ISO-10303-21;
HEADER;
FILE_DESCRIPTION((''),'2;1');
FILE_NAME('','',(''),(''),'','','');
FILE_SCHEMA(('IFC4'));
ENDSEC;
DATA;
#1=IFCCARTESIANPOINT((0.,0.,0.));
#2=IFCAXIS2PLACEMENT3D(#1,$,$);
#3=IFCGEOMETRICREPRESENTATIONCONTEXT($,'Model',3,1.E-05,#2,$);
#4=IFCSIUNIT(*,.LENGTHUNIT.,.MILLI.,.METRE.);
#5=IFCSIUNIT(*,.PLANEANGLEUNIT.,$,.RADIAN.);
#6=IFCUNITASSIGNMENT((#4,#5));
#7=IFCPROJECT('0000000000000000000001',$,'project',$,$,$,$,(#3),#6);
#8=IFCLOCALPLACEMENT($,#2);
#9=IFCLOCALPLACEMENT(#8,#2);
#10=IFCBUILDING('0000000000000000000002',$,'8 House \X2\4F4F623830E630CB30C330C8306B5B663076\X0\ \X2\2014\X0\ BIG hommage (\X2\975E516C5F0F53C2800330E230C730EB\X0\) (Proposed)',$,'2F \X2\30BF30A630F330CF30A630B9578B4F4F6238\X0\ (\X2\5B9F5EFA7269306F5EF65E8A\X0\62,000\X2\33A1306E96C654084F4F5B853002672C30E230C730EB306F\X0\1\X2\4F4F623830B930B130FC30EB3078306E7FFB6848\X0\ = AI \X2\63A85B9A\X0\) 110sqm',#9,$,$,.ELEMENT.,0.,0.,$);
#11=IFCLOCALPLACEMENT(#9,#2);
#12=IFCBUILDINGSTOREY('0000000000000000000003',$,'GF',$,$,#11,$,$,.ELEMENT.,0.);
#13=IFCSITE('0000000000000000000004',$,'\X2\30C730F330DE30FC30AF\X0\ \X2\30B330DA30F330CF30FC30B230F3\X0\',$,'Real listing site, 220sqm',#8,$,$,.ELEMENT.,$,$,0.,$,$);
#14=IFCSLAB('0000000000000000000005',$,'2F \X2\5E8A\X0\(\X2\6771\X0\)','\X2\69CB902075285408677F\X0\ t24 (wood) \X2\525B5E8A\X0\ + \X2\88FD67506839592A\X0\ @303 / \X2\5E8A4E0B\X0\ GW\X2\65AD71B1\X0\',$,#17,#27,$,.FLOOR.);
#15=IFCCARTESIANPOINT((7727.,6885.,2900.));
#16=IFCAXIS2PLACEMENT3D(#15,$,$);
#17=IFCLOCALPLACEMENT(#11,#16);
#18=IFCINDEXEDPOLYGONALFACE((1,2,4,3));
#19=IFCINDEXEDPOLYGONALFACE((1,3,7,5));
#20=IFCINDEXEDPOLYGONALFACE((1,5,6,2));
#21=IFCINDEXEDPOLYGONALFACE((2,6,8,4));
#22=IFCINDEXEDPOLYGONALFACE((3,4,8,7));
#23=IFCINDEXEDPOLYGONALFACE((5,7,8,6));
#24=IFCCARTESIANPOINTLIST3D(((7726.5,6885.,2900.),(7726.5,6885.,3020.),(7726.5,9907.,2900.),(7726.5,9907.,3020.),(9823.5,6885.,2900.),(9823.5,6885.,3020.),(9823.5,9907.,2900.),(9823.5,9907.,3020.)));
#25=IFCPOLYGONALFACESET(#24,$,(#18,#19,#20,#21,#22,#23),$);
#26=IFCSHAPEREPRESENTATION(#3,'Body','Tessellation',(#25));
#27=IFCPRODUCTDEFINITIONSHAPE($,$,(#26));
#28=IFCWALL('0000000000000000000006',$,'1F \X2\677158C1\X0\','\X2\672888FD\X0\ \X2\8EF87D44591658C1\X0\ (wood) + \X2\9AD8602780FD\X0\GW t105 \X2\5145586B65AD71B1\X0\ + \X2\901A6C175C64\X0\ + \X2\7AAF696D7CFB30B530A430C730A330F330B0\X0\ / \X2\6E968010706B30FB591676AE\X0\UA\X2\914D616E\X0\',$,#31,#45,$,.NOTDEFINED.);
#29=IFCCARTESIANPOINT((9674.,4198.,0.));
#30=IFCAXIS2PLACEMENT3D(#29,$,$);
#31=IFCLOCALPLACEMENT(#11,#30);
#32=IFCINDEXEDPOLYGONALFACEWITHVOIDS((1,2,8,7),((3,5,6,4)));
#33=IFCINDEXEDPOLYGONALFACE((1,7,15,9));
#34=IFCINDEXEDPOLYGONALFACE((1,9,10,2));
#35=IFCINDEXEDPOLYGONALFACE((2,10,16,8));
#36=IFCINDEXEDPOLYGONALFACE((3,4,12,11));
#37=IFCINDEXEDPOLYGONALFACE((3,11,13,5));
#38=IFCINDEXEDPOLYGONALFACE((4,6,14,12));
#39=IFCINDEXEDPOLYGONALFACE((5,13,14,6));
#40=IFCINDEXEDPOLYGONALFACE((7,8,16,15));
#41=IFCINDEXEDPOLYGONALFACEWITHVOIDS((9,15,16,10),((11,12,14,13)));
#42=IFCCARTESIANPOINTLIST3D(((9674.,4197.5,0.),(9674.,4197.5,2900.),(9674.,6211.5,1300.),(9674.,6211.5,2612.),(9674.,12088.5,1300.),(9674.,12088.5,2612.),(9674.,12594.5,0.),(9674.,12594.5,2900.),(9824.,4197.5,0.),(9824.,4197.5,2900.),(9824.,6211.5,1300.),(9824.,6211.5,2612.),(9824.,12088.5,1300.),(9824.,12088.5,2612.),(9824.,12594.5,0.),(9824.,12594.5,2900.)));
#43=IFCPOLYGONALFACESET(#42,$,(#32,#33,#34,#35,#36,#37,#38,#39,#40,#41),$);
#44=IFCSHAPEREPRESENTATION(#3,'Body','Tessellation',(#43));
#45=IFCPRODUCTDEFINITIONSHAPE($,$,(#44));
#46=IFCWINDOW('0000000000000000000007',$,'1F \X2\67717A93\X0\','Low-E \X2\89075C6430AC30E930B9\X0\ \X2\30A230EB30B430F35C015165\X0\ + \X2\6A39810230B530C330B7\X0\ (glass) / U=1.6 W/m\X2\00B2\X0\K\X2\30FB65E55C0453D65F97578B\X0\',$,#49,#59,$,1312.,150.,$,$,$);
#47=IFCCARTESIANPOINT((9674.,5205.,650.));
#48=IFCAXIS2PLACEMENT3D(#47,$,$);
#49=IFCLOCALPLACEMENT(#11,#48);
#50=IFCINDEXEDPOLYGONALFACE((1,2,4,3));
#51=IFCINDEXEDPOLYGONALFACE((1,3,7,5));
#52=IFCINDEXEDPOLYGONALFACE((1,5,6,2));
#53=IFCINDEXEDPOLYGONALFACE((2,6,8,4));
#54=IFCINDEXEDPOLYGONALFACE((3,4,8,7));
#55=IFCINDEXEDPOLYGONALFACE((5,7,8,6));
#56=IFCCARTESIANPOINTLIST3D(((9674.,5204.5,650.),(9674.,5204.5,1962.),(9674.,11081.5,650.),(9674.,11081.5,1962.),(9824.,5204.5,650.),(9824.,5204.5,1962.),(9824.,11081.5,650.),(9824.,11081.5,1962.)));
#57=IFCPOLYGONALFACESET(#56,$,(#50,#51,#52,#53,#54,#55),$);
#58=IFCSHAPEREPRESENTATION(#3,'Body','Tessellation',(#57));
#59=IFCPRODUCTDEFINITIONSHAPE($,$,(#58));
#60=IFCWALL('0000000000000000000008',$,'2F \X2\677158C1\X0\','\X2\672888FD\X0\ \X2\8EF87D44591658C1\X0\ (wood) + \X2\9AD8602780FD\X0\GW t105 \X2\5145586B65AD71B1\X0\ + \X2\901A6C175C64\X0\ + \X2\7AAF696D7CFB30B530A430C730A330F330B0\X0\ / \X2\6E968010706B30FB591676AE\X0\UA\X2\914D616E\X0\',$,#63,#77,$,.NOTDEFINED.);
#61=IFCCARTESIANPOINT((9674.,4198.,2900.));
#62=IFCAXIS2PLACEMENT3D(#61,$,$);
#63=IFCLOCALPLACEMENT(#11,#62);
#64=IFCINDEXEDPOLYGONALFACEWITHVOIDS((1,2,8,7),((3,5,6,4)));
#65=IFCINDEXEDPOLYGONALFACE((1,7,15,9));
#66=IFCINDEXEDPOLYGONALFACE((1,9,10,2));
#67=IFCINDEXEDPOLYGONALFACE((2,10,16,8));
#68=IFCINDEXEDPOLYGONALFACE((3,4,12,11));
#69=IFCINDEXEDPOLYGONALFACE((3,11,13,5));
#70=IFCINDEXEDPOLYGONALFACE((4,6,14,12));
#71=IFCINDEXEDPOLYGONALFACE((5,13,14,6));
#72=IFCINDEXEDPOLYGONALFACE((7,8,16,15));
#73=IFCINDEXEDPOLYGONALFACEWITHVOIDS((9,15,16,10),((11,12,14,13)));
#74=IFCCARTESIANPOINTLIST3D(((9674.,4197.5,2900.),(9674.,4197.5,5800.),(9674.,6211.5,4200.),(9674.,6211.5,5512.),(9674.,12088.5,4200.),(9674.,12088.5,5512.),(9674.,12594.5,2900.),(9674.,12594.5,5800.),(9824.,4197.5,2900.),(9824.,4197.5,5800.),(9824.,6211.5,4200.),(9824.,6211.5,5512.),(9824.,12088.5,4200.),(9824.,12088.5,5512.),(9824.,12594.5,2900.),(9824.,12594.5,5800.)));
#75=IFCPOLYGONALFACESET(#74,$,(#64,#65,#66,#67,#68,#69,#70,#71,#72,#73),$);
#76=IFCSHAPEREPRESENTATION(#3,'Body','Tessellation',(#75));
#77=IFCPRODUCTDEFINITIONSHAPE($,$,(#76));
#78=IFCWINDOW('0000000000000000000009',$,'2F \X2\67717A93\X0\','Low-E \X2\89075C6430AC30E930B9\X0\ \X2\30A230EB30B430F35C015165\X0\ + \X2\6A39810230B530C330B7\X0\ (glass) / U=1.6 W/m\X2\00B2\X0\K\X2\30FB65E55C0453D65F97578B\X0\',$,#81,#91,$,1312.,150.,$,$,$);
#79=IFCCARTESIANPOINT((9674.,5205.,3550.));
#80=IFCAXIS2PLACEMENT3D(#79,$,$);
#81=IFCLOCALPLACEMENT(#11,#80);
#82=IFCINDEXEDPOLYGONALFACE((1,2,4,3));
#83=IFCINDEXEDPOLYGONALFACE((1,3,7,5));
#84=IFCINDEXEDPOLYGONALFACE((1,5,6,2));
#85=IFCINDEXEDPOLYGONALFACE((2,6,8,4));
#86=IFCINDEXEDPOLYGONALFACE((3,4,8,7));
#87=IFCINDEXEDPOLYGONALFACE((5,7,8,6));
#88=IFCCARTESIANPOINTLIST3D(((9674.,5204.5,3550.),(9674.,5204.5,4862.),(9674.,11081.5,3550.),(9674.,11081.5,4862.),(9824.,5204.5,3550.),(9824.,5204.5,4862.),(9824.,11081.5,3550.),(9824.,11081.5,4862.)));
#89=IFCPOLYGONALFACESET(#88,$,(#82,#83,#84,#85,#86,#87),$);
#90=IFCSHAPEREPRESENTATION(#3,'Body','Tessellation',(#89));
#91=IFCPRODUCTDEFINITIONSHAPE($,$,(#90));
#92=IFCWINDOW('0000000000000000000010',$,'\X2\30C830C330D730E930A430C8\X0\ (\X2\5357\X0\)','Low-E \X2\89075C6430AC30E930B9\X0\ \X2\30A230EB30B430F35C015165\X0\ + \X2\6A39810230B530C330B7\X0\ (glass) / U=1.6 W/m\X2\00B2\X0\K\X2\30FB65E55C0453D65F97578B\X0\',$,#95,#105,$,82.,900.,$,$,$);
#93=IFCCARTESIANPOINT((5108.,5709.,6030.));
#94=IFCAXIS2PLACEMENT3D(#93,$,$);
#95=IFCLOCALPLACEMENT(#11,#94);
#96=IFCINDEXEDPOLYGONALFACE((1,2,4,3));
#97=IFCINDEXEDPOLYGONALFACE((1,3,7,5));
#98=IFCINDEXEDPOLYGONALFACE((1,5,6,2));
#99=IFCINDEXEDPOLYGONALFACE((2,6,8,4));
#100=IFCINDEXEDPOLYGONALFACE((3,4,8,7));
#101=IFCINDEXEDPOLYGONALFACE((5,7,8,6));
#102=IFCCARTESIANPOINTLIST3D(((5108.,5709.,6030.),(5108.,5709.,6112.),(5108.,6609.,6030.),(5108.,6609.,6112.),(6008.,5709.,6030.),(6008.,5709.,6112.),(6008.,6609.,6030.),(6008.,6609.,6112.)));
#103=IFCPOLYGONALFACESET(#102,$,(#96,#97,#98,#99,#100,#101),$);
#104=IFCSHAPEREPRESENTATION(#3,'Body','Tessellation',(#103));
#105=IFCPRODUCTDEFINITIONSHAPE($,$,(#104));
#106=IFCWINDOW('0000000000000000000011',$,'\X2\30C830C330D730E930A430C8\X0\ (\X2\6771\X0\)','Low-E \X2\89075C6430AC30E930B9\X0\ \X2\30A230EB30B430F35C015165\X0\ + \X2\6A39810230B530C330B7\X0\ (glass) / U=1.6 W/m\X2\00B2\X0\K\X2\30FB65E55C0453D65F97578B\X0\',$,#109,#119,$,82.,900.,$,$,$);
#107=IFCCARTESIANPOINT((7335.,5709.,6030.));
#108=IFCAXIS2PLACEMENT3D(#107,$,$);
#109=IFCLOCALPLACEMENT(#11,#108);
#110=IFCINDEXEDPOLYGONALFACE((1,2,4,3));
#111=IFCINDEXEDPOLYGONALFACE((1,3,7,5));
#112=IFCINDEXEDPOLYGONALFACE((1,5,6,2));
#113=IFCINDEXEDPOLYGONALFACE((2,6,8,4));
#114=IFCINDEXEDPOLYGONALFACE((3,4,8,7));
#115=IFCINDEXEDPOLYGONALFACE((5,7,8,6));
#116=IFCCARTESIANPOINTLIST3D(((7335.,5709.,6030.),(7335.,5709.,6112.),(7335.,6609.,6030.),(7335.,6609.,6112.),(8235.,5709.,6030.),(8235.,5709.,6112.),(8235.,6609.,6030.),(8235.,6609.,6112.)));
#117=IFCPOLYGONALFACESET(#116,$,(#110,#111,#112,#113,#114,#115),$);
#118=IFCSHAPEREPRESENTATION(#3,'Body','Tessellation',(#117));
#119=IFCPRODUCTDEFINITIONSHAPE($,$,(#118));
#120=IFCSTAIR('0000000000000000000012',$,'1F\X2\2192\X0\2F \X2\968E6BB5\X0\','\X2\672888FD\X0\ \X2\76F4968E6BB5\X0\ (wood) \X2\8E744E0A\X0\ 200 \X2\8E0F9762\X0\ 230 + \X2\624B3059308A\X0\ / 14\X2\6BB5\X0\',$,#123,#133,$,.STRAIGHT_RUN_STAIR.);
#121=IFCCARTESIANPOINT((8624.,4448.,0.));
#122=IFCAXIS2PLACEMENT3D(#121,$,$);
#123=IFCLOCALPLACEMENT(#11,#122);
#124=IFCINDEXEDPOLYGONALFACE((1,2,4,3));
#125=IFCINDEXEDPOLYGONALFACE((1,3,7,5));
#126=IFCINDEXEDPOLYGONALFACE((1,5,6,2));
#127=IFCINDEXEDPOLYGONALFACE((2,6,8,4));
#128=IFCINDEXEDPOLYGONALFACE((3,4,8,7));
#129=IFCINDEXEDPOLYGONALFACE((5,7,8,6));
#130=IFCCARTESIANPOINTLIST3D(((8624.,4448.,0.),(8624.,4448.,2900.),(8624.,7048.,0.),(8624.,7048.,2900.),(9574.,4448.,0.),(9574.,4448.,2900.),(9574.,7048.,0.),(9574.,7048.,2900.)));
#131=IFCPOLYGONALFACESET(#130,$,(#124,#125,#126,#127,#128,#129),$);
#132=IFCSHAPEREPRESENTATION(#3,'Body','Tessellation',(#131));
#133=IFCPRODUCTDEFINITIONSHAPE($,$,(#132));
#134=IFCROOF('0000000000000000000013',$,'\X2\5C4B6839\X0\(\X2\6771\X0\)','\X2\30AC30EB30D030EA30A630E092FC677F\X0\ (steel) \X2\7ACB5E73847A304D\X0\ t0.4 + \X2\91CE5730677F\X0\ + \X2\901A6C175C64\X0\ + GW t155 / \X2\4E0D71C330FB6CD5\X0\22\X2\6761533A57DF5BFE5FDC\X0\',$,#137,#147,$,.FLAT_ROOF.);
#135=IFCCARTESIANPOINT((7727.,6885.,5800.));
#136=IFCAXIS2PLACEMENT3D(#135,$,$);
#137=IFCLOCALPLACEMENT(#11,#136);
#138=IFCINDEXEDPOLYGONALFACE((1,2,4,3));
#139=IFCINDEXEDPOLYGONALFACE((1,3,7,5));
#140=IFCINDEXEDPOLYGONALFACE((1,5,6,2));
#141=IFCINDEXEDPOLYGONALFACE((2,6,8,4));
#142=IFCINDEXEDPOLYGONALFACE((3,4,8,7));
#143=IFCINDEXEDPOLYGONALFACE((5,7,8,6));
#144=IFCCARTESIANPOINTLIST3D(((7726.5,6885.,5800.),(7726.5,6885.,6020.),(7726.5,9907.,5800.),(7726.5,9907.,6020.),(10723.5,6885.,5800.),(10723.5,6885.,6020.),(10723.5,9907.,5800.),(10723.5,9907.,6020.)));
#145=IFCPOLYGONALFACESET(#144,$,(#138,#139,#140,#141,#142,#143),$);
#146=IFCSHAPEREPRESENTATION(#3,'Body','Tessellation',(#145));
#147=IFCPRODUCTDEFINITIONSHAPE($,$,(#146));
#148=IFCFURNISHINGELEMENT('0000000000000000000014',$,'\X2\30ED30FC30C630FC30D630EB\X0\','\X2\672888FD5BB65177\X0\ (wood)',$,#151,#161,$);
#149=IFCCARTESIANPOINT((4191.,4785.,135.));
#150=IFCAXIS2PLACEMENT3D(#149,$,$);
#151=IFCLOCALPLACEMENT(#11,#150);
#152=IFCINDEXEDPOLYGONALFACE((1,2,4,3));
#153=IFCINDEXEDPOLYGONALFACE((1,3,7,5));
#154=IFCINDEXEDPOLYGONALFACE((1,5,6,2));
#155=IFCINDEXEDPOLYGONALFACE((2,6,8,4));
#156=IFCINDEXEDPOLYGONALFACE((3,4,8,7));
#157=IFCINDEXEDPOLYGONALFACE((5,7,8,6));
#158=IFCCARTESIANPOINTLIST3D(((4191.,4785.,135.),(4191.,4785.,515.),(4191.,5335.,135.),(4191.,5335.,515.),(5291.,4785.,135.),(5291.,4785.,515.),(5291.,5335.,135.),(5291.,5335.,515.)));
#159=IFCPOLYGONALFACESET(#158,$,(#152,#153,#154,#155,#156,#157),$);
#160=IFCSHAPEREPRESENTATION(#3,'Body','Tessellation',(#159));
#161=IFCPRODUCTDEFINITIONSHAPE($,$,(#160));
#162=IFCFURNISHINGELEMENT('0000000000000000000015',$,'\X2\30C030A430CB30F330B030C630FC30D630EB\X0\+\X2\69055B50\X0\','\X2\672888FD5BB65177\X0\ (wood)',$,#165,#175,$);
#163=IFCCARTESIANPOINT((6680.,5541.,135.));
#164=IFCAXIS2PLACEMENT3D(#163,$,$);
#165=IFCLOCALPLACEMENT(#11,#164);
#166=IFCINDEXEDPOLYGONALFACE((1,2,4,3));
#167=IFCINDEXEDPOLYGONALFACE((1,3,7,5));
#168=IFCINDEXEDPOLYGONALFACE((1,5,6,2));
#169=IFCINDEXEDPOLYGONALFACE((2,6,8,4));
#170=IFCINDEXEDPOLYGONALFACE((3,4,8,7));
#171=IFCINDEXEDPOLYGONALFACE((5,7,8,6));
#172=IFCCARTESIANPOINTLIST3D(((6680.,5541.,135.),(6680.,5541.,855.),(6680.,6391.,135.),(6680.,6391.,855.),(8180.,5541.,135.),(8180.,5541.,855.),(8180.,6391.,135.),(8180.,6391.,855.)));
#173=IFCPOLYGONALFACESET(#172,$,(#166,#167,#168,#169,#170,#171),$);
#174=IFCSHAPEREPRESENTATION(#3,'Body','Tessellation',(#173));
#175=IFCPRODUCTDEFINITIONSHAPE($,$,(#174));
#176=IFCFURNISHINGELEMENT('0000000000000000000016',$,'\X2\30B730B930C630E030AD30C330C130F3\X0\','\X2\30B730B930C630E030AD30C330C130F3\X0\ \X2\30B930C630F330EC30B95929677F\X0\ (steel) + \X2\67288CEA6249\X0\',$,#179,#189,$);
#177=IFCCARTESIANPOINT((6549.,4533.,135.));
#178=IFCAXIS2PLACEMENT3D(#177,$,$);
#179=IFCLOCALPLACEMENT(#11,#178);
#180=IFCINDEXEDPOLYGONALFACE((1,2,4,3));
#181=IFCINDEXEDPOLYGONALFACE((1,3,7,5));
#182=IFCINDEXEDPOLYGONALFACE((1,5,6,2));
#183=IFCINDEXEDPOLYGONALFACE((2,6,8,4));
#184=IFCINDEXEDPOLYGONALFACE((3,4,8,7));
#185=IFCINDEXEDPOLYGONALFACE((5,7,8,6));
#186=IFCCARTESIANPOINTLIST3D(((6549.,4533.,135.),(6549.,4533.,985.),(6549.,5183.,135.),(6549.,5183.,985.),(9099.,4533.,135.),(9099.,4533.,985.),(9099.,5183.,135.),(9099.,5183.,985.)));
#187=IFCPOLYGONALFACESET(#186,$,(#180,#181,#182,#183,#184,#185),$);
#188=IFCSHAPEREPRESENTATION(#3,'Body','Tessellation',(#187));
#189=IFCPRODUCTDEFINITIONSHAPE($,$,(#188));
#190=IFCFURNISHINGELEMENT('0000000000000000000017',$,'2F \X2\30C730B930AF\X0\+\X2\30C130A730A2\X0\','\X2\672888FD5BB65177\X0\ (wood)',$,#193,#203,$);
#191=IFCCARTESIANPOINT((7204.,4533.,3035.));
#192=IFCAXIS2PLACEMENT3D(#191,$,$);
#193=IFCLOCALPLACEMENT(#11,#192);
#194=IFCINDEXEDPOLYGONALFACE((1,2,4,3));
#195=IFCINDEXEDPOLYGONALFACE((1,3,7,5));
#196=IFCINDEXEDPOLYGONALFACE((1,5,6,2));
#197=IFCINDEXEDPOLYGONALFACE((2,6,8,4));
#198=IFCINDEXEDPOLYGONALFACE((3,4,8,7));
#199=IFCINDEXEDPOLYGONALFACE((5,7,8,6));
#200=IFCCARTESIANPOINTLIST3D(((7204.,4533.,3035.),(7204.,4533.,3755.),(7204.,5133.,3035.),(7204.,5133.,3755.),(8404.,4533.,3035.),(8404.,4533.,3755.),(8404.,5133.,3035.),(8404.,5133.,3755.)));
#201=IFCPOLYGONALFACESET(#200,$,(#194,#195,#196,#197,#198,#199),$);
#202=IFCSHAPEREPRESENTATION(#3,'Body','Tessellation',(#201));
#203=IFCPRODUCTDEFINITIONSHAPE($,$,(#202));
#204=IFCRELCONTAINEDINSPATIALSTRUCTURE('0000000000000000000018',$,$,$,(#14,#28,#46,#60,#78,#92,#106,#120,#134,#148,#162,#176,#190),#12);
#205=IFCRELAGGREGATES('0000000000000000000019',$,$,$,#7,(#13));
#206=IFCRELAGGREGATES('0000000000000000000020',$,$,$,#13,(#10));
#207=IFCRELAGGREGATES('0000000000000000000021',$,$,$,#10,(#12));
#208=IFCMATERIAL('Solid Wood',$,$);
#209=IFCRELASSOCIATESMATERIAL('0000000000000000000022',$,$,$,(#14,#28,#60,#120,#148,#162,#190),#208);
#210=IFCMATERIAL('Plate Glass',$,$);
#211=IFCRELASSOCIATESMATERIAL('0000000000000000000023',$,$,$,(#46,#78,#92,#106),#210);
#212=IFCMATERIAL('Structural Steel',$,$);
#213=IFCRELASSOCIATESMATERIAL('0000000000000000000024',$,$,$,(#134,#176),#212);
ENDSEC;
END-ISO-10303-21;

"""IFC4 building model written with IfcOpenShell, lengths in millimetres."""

from ifc_helpers import new_model, si_unit, frame, frame_2d, origin, place, context, project, spatial, rectangle, extrude, material, element, fill, save


model = new_model("IFC4")

# Units and contexts
model_context = context("Model", 3, precision=1e-05, world=origin())
ifc_project = project(units=[si_unit("LENGTHUNIT", "METRE", prefix="MILLI"), si_unit("PLANEANGLEUNIT", "RADIAN")], contexts=[model_context])

# Site, building, storey
site_placement = place(None, origin())
site = spatial("IfcSite", under=ifc_project, at=site_placement, Name="デンマーク コペンハーゲン", ObjectType="Real listing site, 220sqm", CompositionType="ELEMENT", RefElevation=0.0)
building_placement = place(site_placement, origin())
building = spatial("IfcBuilding", under=site, at=building_placement, Name="8 House 住戸ユニットに学ぶ — BIG hommage (非公式参考モデル) (Proposed)", ObjectType="2F タウンハウス型住戸 (実建物は延床62,000㎡の集合住宅。本モデルは1住戸スケールへの翻案 = AI 推定) 110sqm", CompositionType="ELEMENT", ElevationOfRefHeight=0.0, ElevationOfTerrain=0.0)
storey_placement = place(building_placement, origin())
storey = spatial("IfcBuildingStorey", under=building, at=storey_placement, Name="GF", CompositionType="ELEMENT", Elevation=0.0)

# Slab
ifc_material_1 = material(Name="Solid Wood")
slab_1_placement = place(storey_placement, frame((7727.0, 6885.0, 2900.0)))
element("IfcSlab", 1, at=slab_1_placement, inside=storey, material=ifc_material_1, Name="2F 床(東)", Description="構造用合板 t24 (wood) 剛床 + 製材根太 @303 / 床下 GW断熱", PredefinedType="FLOOR", context=model_context, shape_type="SweptSolid", body=[
    extrude(rectangle(XDim=2097.0, YDim=3022.0, at=frame_2d((1048.0, 1511.0))), frame((7727.0, 6885.0, 2900.0)), (0.0, 0.0, 1.0), 120.0),
])

# Wall, opening, window
wall_1_placement = place(storey_placement, frame((9674.0, 4198.0, 0.0)))
wall_1 = element("IfcWall", 2, at=wall_1_placement, inside=storey, material=ifc_material_1, Name="1F 東壁", Description="木製 軸組外壁 (wood) + 高性能GW t105 充填断熱 + 通気層 + 窯業系サイディング / 準耐火・外皮UA配慮", PredefinedType="NOTDEFINED", context=model_context, shape_type="SweptSolid", body=[
    extrude(rectangle(XDim=150.0, YDim=8397.0, at=frame_2d((75.0, 4198.0))), frame((9674.0, 4198.0, 0.0)), (0.0, 0.0, 1.0), 2900.0),
])
opening_1_placement = place(storey_placement, frame((9674.0, 5205.0, 650.0)))
opening_1 = element("IfcOpeningElement", 3, at=opening_1_placement, cuts=wall_1, PredefinedType="NOTDEFINED", context=model_context, shape_type="SweptSolid", body=[
    extrude(rectangle(XDim=150.0, YDim=5877.0, at=frame_2d((75.0, 2938.0))), frame((9674.0, 5205.0, 650.0)), (0.0, 0.0, 1.0), 1312.0),
])
ifc_material_2 = material(Name="Plate Glass")
window_1_placement = place(storey_placement, frame((9674.0, 5205.0, 650.0)))
window_1 = element("IfcWindow", 4, at=window_1_placement, inside=storey, material=ifc_material_2, Name="1F 東窓", Description="Low-E 複層ガラス アルゴン封入 + 樹脂サッシ (glass) / U=1.6 W/m²K・日射取得型", OverallHeight=1312.0, OverallWidth=150.0, context=model_context, shape_type="SweptSolid", body=[
    extrude(rectangle(XDim=150.0, YDim=5877.0, at=frame_2d((75.0, 2938.0))), frame((9674.0, 5205.0, 650.0)), (0.0, 0.0, 1.0), 1312.0),
])
fill(opening_1, window_1)

# Wall, opening, window
wall_2_placement = place(storey_placement, frame((9674.0, 4198.0, 2900.0)))
wall_2 = element("IfcWall", 5, at=wall_2_placement, inside=storey, material=ifc_material_1, Name="2F 東壁", Description="木製 軸組外壁 (wood) + 高性能GW t105 充填断熱 + 通気層 + 窯業系サイディング / 準耐火・外皮UA配慮", PredefinedType="NOTDEFINED", context=model_context, shape_type="SweptSolid", body=[
    extrude(rectangle(XDim=150.0, YDim=8397.0, at=frame_2d((75.0, 4198.0))), frame((9674.0, 4198.0, 2900.0)), (0.0, 0.0, 1.0), 2900.0),
])
opening_2_placement = place(storey_placement, frame((9674.0, 5205.0, 3550.0)))
opening_2 = element("IfcOpeningElement", 6, at=opening_2_placement, cuts=wall_2, PredefinedType="NOTDEFINED", context=model_context, shape_type="SweptSolid", body=[
    extrude(rectangle(XDim=150.0, YDim=5877.0, at=frame_2d((75.0, 2938.0))), frame((9674.0, 5205.0, 3550.0)), (0.0, 0.0, 1.0), 1312.0),
])
window_2_placement = place(storey_placement, frame((9674.0, 5205.0, 3550.0)))
window_2 = element("IfcWindow", 7, at=window_2_placement, inside=storey, material=ifc_material_2, Name="2F 東窓", Description="Low-E 複層ガラス アルゴン封入 + 樹脂サッシ (glass) / U=1.6 W/m²K・日射取得型", OverallHeight=1312.0, OverallWidth=150.0, context=model_context, shape_type="SweptSolid", body=[
    extrude(rectangle(XDim=150.0, YDim=5877.0, at=frame_2d((75.0, 2938.0))), frame((9674.0, 5205.0, 3550.0)), (0.0, 0.0, 1.0), 1312.0),
])
fill(opening_2, window_2)

# Windows
window_3_placement = place(storey_placement, frame((5108.0, 5709.0, 6030.0)))
element("IfcWindow", 8, at=window_3_placement, inside=storey, material=ifc_material_2, Name="トップライト (南)", Description="Low-E 複層ガラス アルゴン封入 + 樹脂サッシ (glass) / U=1.6 W/m²K・日射取得型", OverallHeight=82.0, OverallWidth=900.0, context=model_context, shape_type="SweptSolid", body=[
    extrude(rectangle(XDim=900.0, YDim=900.0, at=frame_2d((450.0, 450.0))), frame((5108.0, 5709.0, 6030.0)), (0.0, 0.0, 1.0), 82.0),
])
window_4_placement = place(storey_placement, frame((7335.0, 5709.0, 6030.0)))
element("IfcWindow", 9, at=window_4_placement, inside=storey, material=ifc_material_2, Name="トップライト (東)", Description="Low-E 複層ガラス アルゴン封入 + 樹脂サッシ (glass) / U=1.6 W/m²K・日射取得型", OverallHeight=82.0, OverallWidth=900.0, context=model_context, shape_type="SweptSolid", body=[
    extrude(rectangle(XDim=900.0, YDim=900.0, at=frame_2d((450.0, 450.0))), frame((7335.0, 5709.0, 6030.0)), (0.0, 0.0, 1.0), 82.0),
])

# Stair
stair_placement = place(storey_placement, frame((8624.0, 4448.0, 0.0)))
element("IfcStair", 10, at=stair_placement, inside=storey, material=ifc_material_1, Name="1F→2F 階段", Description="木製 直階段 (wood) 蹴上 200 踏面 230 + 手すり / 14段", PredefinedType="STRAIGHT_RUN_STAIR", context=model_context, shape_type="SweptSolid", body=[
    extrude(rectangle(XDim=950.0, YDim=2600.0, at=frame_2d((475.0, 1300.0))), frame((8624.0, 4448.0, 0.0)), (0.0, 0.0, 1.0), 2900.0),
])

# Roof
ifc_material_3 = material(Name="Structural Steel")
roof_placement = place(storey_placement, frame((7727.0, 6885.0, 5800.0)))
element("IfcRoof", 11, at=roof_placement, inside=storey, material=ifc_material_3, Name="屋根(東)", Description="ガルバリウム鋼板 (steel) 立平葺き t0.4 + 野地板 + 通気層 + GW t155 / 不燃・法22条区域対応", PredefinedType="FLAT_ROOF", context=model_context, shape_type="SweptSolid", body=[
    extrude(rectangle(XDim=2997.0, YDim=3022.0, at=frame_2d((1498.0, 1511.0))), frame((7727.0, 6885.0, 5800.0)), (0.0, 0.0, 1.0), 220.0),
])

# Furnishing elements
furnishing_1_placement = place(storey_placement, frame((4191.0, 4785.0, 135.0)))
element("IfcFurnishingElement", 12, at=furnishing_1_placement, inside=storey, material=ifc_material_1, Name="ローテーブル", Description="木製家具 (wood)", context=model_context, shape_type="SweptSolid", body=[
    extrude(rectangle(XDim=1100.0, YDim=550.0, at=frame_2d((550.0, 275.0))), frame((4191.0, 4785.0, 135.0)), (0.0, 0.0, 1.0), 380.0),
])
furnishing_2_placement = place(storey_placement, frame((6680.0, 5541.0, 135.0)))
element("IfcFurnishingElement", 13, at=furnishing_2_placement, inside=storey, material=ifc_material_1, Name="ダイニングテーブル+椅子", Description="木製家具 (wood)", context=model_context, shape_type="SweptSolid", body=[
    extrude(rectangle(XDim=1500.0, YDim=850.0, at=frame_2d((750.0, 425.0))), frame((6680.0, 5541.0, 135.0)), (0.0, 0.0, 1.0), 720.0),
])
furnishing_3_placement = place(storey_placement, frame((6549.0, 4533.0, 135.0)))
element("IfcFurnishingElement", 14, at=furnishing_3_placement, inside=storey, material=ifc_material_3, Name="システムキッチン", Description="システムキッチン ステンレス天板 (steel) + 木質扉", context=model_context, shape_type="SweptSolid", body=[
    extrude(rectangle(XDim=2550.0, YDim=650.0, at=frame_2d((1275.0, 325.0))), frame((6549.0, 4533.0, 135.0)), (0.0, 0.0, 1.0), 850.0),
])
furnishing_4_placement = place(storey_placement, frame((7204.0, 4533.0, 3035.0)))
element("IfcFurnishingElement", 15, at=furnishing_4_placement, inside=storey, material=ifc_material_1, Name="2F デスク+チェア", Description="木製家具 (wood)", context=model_context, shape_type="SweptSolid", body=[
    extrude(rectangle(XDim=1200.0, YDim=600.0, at=frame_2d((600.0, 300.0))), frame((7204.0, 4533.0, 3035.0)), (0.0, 0.0, 1.0), 720.0),
])

save(model, "model.ifc")
